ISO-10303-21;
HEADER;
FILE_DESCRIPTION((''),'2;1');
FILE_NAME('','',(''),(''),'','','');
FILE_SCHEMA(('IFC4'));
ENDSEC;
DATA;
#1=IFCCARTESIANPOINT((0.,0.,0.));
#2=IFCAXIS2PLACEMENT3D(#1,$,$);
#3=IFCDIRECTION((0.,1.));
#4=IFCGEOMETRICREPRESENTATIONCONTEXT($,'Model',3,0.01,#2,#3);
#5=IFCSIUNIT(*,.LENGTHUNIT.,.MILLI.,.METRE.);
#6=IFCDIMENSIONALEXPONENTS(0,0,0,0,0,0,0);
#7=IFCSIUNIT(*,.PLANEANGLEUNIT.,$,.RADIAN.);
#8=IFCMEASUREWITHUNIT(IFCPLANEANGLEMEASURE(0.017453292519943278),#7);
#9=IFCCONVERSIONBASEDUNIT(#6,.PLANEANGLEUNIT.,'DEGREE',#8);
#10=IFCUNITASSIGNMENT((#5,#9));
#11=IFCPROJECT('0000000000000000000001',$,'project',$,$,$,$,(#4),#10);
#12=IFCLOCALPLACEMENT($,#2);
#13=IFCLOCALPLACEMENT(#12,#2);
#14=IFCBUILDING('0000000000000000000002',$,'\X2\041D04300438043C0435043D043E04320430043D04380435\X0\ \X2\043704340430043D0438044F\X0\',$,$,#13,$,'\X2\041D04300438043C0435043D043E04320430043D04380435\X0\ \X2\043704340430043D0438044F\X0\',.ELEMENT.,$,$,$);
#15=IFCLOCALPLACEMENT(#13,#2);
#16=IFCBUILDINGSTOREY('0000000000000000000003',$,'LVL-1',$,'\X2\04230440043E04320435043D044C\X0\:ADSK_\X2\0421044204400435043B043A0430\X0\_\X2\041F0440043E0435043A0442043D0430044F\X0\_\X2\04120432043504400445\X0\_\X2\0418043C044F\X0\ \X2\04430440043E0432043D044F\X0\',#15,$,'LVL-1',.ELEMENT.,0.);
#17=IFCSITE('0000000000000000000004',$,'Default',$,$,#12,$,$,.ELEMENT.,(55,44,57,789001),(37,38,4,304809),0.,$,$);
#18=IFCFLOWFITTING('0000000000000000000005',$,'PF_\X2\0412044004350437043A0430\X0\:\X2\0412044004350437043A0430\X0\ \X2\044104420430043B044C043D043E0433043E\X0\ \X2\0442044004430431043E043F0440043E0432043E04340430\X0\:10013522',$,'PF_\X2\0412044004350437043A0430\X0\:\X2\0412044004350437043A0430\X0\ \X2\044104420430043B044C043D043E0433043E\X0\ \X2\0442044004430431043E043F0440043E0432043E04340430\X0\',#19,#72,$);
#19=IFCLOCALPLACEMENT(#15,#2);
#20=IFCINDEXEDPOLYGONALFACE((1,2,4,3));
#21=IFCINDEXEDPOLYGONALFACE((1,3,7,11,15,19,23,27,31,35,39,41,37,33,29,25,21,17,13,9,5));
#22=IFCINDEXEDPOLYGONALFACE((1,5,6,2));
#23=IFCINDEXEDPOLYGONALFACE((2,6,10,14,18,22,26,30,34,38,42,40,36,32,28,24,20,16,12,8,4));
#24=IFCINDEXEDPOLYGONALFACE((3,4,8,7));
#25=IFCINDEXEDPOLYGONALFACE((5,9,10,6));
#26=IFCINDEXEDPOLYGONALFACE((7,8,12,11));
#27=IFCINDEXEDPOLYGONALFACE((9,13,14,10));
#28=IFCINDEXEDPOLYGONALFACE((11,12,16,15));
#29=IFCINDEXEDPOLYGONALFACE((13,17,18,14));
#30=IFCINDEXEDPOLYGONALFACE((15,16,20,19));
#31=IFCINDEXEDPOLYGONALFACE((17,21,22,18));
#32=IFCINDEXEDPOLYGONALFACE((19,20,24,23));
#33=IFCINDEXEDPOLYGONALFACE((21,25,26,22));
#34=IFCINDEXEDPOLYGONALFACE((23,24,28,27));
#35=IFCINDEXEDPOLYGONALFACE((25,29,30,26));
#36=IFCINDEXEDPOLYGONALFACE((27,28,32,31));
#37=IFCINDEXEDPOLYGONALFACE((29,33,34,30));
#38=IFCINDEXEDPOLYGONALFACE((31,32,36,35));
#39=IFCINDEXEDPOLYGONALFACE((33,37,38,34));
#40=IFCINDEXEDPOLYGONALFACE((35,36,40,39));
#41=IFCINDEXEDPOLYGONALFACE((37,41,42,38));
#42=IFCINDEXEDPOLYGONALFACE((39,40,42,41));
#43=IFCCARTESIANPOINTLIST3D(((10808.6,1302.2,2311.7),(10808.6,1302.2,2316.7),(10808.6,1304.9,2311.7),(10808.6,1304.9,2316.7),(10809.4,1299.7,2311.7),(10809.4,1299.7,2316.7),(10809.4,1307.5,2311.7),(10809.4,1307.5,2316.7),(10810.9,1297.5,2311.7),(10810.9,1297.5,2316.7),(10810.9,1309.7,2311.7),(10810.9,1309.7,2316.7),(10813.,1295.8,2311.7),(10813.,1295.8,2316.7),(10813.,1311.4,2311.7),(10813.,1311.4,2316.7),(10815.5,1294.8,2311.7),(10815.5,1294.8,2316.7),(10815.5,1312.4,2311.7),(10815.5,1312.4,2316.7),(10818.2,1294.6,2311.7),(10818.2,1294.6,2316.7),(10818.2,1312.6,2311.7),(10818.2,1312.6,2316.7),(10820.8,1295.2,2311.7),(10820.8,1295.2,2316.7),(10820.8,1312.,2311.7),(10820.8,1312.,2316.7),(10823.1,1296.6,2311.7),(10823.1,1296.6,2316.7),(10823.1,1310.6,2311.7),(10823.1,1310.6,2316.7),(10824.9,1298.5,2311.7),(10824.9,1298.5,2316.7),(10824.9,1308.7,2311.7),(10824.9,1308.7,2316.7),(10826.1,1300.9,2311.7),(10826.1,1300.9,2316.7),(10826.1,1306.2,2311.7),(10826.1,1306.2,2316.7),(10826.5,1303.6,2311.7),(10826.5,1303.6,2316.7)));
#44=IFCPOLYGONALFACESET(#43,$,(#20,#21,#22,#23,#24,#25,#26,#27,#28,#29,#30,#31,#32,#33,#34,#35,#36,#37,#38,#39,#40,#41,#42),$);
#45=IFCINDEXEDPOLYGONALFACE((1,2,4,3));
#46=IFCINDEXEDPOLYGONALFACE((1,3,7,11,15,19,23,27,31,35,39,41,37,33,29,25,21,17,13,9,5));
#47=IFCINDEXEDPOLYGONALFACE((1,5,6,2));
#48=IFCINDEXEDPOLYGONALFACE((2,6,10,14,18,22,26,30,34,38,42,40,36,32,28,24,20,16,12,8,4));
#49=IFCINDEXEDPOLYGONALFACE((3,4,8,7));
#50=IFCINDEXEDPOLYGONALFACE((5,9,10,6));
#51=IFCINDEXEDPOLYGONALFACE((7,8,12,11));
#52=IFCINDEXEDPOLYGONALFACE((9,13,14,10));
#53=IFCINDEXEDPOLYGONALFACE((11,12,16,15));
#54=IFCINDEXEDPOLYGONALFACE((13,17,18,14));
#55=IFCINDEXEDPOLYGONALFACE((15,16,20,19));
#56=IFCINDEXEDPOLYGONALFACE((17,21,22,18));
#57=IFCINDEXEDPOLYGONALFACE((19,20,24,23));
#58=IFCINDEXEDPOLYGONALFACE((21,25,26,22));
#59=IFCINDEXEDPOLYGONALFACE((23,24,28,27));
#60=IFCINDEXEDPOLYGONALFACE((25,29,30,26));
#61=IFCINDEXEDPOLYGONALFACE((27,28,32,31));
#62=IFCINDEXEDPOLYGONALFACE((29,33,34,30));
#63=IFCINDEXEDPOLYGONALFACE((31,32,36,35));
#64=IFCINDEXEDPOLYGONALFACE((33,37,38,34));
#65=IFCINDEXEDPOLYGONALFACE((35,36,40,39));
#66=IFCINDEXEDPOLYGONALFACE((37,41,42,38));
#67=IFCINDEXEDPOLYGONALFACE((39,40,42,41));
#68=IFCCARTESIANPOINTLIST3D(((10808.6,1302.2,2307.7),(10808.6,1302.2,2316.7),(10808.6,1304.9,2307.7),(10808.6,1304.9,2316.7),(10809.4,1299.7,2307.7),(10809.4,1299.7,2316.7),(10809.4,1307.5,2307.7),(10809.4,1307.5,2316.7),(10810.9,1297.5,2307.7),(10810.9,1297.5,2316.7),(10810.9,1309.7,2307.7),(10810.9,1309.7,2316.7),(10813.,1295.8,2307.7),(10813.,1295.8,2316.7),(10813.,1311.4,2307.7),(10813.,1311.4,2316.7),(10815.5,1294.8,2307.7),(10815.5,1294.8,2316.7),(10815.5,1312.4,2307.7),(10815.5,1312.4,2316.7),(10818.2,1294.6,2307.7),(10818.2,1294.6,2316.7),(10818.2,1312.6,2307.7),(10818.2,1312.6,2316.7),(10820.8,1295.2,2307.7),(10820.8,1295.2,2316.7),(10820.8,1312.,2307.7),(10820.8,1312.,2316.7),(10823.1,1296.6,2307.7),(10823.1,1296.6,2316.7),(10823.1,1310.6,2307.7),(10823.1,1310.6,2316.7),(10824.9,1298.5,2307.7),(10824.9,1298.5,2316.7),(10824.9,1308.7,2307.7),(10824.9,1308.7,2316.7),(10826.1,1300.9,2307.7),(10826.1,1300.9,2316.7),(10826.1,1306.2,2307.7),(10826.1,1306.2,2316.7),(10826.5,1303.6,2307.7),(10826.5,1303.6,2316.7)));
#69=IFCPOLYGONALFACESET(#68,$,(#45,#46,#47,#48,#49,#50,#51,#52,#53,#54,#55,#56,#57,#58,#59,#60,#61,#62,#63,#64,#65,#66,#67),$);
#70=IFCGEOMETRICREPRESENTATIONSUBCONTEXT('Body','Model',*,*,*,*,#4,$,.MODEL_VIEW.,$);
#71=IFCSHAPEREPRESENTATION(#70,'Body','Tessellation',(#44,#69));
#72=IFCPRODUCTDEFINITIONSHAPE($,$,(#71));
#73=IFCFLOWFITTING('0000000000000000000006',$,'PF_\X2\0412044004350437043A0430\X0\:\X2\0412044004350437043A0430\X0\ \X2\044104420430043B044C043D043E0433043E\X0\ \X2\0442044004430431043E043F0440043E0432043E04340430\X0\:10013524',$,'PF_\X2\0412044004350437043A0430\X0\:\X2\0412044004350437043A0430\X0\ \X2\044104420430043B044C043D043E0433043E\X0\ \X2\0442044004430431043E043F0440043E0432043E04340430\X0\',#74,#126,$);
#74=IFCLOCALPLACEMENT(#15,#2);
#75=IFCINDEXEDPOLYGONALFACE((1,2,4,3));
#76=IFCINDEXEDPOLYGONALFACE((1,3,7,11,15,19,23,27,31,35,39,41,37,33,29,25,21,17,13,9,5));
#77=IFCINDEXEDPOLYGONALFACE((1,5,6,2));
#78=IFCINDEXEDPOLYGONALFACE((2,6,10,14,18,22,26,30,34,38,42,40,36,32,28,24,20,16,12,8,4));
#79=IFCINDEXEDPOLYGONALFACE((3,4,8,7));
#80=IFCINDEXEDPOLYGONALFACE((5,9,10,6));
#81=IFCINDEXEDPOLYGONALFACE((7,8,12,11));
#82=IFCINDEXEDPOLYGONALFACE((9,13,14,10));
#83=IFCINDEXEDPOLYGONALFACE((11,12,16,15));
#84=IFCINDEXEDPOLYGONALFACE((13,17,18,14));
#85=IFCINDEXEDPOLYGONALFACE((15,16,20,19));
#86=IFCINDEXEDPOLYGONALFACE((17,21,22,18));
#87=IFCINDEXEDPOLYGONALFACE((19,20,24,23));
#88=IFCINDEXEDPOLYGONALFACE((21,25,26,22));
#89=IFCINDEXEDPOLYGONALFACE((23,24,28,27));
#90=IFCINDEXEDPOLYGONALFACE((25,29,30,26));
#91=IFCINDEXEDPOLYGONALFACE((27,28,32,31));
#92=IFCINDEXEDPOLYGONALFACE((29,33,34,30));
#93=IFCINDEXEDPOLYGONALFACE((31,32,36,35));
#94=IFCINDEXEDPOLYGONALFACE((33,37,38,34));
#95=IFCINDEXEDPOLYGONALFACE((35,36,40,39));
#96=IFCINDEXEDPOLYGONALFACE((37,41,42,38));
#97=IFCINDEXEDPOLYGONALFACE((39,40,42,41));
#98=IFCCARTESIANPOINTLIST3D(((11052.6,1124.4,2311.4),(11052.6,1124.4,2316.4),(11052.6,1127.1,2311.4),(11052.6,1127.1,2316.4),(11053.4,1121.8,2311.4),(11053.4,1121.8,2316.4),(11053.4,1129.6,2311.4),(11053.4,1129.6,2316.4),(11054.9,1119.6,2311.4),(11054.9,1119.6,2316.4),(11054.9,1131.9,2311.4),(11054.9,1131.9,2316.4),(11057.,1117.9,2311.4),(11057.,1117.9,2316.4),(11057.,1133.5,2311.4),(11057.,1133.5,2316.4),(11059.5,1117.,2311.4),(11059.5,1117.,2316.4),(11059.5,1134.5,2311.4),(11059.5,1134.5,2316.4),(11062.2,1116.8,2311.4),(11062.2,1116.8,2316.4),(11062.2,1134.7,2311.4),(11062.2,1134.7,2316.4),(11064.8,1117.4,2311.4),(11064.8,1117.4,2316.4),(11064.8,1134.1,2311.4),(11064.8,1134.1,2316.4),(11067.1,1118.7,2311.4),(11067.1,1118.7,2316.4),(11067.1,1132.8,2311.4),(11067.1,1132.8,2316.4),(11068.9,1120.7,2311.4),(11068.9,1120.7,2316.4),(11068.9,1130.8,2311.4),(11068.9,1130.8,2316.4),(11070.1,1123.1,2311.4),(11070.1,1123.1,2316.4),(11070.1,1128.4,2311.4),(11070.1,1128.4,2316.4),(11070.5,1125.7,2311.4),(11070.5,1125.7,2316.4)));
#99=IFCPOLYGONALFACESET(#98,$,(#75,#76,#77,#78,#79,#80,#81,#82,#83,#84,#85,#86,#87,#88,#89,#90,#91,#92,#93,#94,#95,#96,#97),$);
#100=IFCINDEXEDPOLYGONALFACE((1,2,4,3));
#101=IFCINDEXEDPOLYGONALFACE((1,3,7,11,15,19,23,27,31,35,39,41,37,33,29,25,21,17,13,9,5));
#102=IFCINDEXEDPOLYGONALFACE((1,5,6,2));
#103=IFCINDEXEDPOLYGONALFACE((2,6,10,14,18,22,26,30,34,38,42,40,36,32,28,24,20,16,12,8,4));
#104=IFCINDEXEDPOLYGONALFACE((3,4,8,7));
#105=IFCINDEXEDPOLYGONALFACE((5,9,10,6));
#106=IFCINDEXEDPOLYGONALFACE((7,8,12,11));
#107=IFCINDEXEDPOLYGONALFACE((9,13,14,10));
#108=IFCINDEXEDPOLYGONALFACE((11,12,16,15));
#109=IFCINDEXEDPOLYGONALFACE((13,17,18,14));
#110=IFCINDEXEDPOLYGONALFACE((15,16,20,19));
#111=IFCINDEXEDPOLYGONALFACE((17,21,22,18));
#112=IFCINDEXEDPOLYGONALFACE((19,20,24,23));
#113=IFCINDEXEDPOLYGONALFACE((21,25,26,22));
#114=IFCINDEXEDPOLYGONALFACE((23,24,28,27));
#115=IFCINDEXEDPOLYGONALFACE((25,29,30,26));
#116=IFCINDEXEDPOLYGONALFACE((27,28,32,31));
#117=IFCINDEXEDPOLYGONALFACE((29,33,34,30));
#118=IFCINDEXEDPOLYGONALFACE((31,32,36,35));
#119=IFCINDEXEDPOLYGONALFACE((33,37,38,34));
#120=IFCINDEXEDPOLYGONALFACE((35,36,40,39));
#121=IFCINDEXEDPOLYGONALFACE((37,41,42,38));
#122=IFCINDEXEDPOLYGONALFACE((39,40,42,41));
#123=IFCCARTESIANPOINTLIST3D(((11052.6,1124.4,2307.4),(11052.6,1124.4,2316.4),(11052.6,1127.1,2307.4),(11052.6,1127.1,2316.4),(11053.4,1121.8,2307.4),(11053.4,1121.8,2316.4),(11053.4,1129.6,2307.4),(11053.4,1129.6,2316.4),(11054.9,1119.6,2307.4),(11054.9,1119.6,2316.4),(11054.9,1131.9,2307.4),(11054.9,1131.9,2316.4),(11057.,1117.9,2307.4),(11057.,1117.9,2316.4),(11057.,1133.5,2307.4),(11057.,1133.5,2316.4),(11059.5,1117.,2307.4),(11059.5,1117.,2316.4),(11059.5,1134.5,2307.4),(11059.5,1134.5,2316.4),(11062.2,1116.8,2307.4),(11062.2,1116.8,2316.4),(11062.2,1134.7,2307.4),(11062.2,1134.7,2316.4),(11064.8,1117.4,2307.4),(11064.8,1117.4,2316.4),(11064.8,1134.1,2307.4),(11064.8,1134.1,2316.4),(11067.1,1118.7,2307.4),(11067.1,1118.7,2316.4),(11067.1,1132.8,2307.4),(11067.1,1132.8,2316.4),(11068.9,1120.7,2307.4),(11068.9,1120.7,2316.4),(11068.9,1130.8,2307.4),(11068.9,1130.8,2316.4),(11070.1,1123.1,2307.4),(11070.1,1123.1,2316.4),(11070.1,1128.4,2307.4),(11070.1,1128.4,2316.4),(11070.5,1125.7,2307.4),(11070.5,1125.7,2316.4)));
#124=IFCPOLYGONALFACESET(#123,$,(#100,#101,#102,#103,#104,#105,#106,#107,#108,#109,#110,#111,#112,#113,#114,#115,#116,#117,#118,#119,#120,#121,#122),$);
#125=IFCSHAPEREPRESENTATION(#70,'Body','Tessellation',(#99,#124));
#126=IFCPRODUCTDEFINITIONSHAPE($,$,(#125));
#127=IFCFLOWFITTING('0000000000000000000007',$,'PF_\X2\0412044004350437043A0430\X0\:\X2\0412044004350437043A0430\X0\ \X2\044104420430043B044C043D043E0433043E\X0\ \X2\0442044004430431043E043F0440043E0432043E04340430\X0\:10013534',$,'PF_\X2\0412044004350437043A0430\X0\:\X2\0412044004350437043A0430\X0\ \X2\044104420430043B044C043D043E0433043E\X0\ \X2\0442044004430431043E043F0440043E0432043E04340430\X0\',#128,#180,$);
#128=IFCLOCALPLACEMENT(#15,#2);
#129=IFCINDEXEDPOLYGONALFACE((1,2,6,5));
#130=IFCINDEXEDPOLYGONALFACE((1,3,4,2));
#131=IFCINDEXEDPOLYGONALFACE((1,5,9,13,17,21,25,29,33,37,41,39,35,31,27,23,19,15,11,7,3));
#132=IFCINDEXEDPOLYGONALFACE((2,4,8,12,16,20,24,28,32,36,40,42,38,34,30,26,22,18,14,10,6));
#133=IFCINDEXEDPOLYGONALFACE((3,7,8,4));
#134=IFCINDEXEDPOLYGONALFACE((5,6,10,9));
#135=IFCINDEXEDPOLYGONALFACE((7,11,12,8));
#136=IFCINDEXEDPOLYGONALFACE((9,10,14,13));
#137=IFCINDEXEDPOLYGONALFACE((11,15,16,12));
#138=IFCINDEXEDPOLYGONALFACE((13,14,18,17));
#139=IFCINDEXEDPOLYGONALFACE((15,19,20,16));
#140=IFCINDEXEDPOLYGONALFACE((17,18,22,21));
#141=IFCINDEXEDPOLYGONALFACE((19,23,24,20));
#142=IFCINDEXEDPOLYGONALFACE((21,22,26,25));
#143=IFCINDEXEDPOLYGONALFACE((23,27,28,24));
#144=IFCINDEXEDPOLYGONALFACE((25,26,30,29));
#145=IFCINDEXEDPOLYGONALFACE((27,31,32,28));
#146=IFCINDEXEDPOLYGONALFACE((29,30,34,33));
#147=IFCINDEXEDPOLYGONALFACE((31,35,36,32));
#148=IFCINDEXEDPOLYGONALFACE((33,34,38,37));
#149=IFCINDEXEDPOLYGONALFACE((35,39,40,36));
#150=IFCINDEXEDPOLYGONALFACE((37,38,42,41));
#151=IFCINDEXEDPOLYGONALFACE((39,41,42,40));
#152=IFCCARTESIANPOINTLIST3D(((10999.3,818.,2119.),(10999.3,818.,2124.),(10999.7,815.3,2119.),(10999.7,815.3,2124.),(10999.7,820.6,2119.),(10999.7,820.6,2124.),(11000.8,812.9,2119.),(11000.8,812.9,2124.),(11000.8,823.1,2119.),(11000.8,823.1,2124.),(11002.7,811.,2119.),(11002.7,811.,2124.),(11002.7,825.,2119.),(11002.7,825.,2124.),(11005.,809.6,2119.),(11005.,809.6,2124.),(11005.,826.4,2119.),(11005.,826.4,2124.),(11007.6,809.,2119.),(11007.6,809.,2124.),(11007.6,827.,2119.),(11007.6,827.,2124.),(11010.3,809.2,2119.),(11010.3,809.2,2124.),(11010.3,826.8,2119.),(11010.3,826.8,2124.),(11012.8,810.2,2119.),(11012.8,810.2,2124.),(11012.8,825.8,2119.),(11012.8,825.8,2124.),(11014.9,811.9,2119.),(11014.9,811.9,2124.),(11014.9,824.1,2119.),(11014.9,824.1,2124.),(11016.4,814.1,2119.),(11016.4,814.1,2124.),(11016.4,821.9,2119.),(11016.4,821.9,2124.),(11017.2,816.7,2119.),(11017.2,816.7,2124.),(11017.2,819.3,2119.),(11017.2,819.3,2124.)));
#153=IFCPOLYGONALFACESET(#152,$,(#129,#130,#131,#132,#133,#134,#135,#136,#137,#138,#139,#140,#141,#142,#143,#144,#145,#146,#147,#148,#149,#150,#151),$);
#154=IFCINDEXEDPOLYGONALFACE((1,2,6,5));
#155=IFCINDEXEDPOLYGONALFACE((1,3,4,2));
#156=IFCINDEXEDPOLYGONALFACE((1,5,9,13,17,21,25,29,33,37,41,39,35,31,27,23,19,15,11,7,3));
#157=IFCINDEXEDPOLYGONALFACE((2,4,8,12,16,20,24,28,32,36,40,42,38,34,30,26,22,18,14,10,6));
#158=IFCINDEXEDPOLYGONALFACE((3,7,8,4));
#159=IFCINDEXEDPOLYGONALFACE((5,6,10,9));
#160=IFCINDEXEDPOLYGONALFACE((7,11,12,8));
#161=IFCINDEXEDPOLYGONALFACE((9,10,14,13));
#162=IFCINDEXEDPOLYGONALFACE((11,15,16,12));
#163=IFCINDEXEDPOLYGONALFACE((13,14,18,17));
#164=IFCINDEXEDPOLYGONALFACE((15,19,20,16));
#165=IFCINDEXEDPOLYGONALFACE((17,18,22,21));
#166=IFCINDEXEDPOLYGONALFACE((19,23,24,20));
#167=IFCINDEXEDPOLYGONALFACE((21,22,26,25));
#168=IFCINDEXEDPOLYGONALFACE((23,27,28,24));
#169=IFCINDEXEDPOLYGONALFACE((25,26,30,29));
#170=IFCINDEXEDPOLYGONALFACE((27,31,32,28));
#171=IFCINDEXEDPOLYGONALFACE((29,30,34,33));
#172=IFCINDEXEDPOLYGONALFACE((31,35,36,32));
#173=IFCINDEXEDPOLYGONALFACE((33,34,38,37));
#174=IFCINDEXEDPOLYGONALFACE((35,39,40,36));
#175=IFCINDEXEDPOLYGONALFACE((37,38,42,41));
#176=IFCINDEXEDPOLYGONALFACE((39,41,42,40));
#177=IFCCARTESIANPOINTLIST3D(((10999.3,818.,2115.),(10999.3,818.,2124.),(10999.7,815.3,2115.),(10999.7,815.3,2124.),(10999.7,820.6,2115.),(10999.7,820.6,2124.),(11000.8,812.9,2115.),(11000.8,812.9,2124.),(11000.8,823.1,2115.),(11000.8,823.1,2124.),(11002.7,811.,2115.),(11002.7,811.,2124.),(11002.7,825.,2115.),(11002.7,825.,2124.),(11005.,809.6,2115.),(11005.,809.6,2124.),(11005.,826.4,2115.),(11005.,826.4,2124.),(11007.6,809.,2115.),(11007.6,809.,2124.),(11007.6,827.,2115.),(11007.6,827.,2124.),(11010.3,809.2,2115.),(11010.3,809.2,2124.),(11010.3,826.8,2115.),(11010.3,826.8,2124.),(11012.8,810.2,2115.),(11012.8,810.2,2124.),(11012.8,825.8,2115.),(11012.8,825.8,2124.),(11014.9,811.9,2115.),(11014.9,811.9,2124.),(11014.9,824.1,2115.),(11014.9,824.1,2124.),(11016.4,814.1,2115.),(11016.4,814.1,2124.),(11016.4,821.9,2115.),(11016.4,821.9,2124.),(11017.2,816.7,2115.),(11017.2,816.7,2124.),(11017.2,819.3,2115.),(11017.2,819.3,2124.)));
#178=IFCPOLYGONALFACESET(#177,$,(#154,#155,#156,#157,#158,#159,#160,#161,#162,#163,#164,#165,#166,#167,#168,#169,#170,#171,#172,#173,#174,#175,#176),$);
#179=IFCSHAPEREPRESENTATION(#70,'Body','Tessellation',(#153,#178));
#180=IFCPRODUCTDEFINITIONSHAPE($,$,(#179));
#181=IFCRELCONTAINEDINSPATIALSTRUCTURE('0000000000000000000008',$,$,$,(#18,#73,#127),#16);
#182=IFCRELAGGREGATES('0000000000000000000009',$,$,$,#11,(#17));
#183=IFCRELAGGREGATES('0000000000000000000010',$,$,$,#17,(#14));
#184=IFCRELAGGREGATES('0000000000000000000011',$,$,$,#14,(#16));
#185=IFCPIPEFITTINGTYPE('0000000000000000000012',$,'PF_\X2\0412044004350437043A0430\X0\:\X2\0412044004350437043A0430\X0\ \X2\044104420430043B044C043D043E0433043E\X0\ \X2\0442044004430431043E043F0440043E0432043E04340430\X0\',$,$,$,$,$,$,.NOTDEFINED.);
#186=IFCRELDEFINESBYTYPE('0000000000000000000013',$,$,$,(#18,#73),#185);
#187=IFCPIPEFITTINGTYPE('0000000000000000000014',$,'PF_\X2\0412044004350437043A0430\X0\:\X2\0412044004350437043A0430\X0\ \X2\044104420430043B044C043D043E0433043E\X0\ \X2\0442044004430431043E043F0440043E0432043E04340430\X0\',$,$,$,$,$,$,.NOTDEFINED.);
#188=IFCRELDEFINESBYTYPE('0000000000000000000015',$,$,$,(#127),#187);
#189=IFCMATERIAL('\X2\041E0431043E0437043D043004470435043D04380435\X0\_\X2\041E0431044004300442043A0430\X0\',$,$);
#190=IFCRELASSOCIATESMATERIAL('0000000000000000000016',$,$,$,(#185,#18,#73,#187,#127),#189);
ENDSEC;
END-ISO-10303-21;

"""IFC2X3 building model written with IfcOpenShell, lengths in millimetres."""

from ifc_helpers import new_model, entity, si_unit, converted_unit, direction, frame, frame_2d, origin, place, context, subcontext, project, spatial, circle, extrude, source, transform, mapped, material, type_object, type_shapes, element, save


model = new_model("IFC2X3")

# Units and contexts
model_context = context("Model", 3, precision=0.01, world=origin(), true_north=direction((0.0, 1.0)))
body_context = subcontext(model_context, "Body", "Model", "MODEL_VIEW")
ifc_project = project(units=[si_unit("LENGTHUNIT", "METRE", prefix="MILLI"), converted_unit("PLANEANGLEUNIT", "DEGREE", entity("IfcPlaneAngleMeasure", 0.017453292519943278), si_unit("PLANEANGLEUNIT", "RADIAN"), dimensions=[0, 0, 0, 0, 0, 0, 0])], contexts=[model_context])

# Site, building, storey
site_placement = place(None, origin())
site = spatial("IfcSite", under=ifc_project, at=site_placement, Name="Default", CompositionType="ELEMENT", RefLatitude=(55, 44, 57, 789001), RefLongitude=(37, 38, 4, 304809), RefElevation=0.0)
building_placement = place(site_placement, origin())
building = spatial("IfcBuilding", under=site, at=building_placement, Name="Наименование здания", LongName="Наименование здания", CompositionType="ELEMENT")
storey_placement = place(building_placement, origin())
storey = spatial("IfcBuildingStorey", under=building, at=storey_placement, Name="LVL-1", ObjectType="Уровень:ADSK_Стрелка_Проектная_Вверх_Имя уровня", LongName="LVL-1", CompositionType="ELEMENT", Elevation=0.0)

# Flow fittings
ifc_material_1 = material(Name="Обозначение_Обратка")
pipe_fitting_type_1 = type_object("IfcPipeFittingType", Name="PF_Врезка:Врезка стального трубопровода", PredefinedType="NOTDEFINED", material=ifc_material_1)
shared_shape_1 = source(origin(), body_context, "Body", "SweptSolid", [
    extrude(circle(Radius=9.0, at=frame_2d((0.0, 0.0), x_axis=(1.0, 0.0))), frame((-5.0, 0.0, 0.0), z_axis=(1.0, 0.0, 0.0), x_axis=(0.0, -1.0, 0.0)), (0.0, 0.0, 1.0), 5.0),
    extrude(circle(Radius=9.0, at=frame_2d((0.0, 0.0), x_axis=(1.0, 0.0))), frame((-9.0, 0.0, 0.0), z_axis=(1.0, 0.0, 0.0), x_axis=(0.0, -1.0, 0.0)), (0.0, 0.0, 1.0), 9.0),
])
type_shapes(pipe_fitting_type_1, [shared_shape_1])
for number, where, z_axis, x_axis, name in (
    (1, (10817.5, 1303.6, 2316.7), (0.0, -1.0, 0.0), (0.0, 0.0, 1.0), "PF_Врезка:Врезка стального трубопровода:10013522"),
    (2, (11061.5, 1125.7, 2316.4), (0.0, -1.0, 0.0), (0.0, 0.0, 1.0), "PF_Врезка:Врезка стального трубопровода:10013524"),
):
    element("IfcFlowFitting", number, at=place(storey_placement, frame(where, z_axis=z_axis, x_axis=x_axis)), inside=storey, type_object=pipe_fitting_type_1, material=ifc_material_1, Name=name, ObjectType="PF_Врезка:Врезка стального трубопровода", context=body_context, shape_type="MappedRepresentation", body=[
        mapped(shared_shape_1, transform((0.0, 0.0, 0.0), scale=1.0)),
    ])
pipe_fitting_type_2 = type_object("IfcPipeFittingType", Name="PF_Врезка:Врезка стального трубопровода", PredefinedType="NOTDEFINED", material=ifc_material_1)
shared_shape_2 = source(origin(), body_context, "Body", "SweptSolid", [
    extrude(circle(Radius=9.0, at=frame_2d((0.0, 0.0), x_axis=(1.0, 0.0))), frame((-5.0, 0.0, 0.0), z_axis=(1.0, 0.0, 0.0), x_axis=(0.0, 1.0, 0.0)), (0.0, 0.0, 1.0), 5.0),
    extrude(circle(Radius=9.0, at=frame_2d((0.0, 0.0), x_axis=(1.0, 0.0))), frame((-9.0, 0.0, 0.0), z_axis=(1.0, 0.0, 0.0), x_axis=(0.0, 1.0, 0.0)), (0.0, 0.0, 1.0), 9.0),
])
type_shapes(pipe_fitting_type_2, [shared_shape_2])
flow_fitting_1_placement = place(storey_placement, frame((11008.3, 818.0, 2124.0), z_axis=(0.0, -1.0, 0.0), x_axis=(0.0, 0.0, 1.0)))
element("IfcFlowFitting", 3, at=flow_fitting_1_placement, inside=storey, type_object=pipe_fitting_type_2, material=ifc_material_1, Name="PF_Врезка:Врезка стального трубопровода:10013534", ObjectType="PF_Врезка:Врезка стального трубопровода", context=body_context, shape_type="MappedRepresentation", body=[
    mapped(shared_shape_2, transform((0.0, 0.0, 0.0), scale=1.0)),
])

save(model, "model.ifc")
